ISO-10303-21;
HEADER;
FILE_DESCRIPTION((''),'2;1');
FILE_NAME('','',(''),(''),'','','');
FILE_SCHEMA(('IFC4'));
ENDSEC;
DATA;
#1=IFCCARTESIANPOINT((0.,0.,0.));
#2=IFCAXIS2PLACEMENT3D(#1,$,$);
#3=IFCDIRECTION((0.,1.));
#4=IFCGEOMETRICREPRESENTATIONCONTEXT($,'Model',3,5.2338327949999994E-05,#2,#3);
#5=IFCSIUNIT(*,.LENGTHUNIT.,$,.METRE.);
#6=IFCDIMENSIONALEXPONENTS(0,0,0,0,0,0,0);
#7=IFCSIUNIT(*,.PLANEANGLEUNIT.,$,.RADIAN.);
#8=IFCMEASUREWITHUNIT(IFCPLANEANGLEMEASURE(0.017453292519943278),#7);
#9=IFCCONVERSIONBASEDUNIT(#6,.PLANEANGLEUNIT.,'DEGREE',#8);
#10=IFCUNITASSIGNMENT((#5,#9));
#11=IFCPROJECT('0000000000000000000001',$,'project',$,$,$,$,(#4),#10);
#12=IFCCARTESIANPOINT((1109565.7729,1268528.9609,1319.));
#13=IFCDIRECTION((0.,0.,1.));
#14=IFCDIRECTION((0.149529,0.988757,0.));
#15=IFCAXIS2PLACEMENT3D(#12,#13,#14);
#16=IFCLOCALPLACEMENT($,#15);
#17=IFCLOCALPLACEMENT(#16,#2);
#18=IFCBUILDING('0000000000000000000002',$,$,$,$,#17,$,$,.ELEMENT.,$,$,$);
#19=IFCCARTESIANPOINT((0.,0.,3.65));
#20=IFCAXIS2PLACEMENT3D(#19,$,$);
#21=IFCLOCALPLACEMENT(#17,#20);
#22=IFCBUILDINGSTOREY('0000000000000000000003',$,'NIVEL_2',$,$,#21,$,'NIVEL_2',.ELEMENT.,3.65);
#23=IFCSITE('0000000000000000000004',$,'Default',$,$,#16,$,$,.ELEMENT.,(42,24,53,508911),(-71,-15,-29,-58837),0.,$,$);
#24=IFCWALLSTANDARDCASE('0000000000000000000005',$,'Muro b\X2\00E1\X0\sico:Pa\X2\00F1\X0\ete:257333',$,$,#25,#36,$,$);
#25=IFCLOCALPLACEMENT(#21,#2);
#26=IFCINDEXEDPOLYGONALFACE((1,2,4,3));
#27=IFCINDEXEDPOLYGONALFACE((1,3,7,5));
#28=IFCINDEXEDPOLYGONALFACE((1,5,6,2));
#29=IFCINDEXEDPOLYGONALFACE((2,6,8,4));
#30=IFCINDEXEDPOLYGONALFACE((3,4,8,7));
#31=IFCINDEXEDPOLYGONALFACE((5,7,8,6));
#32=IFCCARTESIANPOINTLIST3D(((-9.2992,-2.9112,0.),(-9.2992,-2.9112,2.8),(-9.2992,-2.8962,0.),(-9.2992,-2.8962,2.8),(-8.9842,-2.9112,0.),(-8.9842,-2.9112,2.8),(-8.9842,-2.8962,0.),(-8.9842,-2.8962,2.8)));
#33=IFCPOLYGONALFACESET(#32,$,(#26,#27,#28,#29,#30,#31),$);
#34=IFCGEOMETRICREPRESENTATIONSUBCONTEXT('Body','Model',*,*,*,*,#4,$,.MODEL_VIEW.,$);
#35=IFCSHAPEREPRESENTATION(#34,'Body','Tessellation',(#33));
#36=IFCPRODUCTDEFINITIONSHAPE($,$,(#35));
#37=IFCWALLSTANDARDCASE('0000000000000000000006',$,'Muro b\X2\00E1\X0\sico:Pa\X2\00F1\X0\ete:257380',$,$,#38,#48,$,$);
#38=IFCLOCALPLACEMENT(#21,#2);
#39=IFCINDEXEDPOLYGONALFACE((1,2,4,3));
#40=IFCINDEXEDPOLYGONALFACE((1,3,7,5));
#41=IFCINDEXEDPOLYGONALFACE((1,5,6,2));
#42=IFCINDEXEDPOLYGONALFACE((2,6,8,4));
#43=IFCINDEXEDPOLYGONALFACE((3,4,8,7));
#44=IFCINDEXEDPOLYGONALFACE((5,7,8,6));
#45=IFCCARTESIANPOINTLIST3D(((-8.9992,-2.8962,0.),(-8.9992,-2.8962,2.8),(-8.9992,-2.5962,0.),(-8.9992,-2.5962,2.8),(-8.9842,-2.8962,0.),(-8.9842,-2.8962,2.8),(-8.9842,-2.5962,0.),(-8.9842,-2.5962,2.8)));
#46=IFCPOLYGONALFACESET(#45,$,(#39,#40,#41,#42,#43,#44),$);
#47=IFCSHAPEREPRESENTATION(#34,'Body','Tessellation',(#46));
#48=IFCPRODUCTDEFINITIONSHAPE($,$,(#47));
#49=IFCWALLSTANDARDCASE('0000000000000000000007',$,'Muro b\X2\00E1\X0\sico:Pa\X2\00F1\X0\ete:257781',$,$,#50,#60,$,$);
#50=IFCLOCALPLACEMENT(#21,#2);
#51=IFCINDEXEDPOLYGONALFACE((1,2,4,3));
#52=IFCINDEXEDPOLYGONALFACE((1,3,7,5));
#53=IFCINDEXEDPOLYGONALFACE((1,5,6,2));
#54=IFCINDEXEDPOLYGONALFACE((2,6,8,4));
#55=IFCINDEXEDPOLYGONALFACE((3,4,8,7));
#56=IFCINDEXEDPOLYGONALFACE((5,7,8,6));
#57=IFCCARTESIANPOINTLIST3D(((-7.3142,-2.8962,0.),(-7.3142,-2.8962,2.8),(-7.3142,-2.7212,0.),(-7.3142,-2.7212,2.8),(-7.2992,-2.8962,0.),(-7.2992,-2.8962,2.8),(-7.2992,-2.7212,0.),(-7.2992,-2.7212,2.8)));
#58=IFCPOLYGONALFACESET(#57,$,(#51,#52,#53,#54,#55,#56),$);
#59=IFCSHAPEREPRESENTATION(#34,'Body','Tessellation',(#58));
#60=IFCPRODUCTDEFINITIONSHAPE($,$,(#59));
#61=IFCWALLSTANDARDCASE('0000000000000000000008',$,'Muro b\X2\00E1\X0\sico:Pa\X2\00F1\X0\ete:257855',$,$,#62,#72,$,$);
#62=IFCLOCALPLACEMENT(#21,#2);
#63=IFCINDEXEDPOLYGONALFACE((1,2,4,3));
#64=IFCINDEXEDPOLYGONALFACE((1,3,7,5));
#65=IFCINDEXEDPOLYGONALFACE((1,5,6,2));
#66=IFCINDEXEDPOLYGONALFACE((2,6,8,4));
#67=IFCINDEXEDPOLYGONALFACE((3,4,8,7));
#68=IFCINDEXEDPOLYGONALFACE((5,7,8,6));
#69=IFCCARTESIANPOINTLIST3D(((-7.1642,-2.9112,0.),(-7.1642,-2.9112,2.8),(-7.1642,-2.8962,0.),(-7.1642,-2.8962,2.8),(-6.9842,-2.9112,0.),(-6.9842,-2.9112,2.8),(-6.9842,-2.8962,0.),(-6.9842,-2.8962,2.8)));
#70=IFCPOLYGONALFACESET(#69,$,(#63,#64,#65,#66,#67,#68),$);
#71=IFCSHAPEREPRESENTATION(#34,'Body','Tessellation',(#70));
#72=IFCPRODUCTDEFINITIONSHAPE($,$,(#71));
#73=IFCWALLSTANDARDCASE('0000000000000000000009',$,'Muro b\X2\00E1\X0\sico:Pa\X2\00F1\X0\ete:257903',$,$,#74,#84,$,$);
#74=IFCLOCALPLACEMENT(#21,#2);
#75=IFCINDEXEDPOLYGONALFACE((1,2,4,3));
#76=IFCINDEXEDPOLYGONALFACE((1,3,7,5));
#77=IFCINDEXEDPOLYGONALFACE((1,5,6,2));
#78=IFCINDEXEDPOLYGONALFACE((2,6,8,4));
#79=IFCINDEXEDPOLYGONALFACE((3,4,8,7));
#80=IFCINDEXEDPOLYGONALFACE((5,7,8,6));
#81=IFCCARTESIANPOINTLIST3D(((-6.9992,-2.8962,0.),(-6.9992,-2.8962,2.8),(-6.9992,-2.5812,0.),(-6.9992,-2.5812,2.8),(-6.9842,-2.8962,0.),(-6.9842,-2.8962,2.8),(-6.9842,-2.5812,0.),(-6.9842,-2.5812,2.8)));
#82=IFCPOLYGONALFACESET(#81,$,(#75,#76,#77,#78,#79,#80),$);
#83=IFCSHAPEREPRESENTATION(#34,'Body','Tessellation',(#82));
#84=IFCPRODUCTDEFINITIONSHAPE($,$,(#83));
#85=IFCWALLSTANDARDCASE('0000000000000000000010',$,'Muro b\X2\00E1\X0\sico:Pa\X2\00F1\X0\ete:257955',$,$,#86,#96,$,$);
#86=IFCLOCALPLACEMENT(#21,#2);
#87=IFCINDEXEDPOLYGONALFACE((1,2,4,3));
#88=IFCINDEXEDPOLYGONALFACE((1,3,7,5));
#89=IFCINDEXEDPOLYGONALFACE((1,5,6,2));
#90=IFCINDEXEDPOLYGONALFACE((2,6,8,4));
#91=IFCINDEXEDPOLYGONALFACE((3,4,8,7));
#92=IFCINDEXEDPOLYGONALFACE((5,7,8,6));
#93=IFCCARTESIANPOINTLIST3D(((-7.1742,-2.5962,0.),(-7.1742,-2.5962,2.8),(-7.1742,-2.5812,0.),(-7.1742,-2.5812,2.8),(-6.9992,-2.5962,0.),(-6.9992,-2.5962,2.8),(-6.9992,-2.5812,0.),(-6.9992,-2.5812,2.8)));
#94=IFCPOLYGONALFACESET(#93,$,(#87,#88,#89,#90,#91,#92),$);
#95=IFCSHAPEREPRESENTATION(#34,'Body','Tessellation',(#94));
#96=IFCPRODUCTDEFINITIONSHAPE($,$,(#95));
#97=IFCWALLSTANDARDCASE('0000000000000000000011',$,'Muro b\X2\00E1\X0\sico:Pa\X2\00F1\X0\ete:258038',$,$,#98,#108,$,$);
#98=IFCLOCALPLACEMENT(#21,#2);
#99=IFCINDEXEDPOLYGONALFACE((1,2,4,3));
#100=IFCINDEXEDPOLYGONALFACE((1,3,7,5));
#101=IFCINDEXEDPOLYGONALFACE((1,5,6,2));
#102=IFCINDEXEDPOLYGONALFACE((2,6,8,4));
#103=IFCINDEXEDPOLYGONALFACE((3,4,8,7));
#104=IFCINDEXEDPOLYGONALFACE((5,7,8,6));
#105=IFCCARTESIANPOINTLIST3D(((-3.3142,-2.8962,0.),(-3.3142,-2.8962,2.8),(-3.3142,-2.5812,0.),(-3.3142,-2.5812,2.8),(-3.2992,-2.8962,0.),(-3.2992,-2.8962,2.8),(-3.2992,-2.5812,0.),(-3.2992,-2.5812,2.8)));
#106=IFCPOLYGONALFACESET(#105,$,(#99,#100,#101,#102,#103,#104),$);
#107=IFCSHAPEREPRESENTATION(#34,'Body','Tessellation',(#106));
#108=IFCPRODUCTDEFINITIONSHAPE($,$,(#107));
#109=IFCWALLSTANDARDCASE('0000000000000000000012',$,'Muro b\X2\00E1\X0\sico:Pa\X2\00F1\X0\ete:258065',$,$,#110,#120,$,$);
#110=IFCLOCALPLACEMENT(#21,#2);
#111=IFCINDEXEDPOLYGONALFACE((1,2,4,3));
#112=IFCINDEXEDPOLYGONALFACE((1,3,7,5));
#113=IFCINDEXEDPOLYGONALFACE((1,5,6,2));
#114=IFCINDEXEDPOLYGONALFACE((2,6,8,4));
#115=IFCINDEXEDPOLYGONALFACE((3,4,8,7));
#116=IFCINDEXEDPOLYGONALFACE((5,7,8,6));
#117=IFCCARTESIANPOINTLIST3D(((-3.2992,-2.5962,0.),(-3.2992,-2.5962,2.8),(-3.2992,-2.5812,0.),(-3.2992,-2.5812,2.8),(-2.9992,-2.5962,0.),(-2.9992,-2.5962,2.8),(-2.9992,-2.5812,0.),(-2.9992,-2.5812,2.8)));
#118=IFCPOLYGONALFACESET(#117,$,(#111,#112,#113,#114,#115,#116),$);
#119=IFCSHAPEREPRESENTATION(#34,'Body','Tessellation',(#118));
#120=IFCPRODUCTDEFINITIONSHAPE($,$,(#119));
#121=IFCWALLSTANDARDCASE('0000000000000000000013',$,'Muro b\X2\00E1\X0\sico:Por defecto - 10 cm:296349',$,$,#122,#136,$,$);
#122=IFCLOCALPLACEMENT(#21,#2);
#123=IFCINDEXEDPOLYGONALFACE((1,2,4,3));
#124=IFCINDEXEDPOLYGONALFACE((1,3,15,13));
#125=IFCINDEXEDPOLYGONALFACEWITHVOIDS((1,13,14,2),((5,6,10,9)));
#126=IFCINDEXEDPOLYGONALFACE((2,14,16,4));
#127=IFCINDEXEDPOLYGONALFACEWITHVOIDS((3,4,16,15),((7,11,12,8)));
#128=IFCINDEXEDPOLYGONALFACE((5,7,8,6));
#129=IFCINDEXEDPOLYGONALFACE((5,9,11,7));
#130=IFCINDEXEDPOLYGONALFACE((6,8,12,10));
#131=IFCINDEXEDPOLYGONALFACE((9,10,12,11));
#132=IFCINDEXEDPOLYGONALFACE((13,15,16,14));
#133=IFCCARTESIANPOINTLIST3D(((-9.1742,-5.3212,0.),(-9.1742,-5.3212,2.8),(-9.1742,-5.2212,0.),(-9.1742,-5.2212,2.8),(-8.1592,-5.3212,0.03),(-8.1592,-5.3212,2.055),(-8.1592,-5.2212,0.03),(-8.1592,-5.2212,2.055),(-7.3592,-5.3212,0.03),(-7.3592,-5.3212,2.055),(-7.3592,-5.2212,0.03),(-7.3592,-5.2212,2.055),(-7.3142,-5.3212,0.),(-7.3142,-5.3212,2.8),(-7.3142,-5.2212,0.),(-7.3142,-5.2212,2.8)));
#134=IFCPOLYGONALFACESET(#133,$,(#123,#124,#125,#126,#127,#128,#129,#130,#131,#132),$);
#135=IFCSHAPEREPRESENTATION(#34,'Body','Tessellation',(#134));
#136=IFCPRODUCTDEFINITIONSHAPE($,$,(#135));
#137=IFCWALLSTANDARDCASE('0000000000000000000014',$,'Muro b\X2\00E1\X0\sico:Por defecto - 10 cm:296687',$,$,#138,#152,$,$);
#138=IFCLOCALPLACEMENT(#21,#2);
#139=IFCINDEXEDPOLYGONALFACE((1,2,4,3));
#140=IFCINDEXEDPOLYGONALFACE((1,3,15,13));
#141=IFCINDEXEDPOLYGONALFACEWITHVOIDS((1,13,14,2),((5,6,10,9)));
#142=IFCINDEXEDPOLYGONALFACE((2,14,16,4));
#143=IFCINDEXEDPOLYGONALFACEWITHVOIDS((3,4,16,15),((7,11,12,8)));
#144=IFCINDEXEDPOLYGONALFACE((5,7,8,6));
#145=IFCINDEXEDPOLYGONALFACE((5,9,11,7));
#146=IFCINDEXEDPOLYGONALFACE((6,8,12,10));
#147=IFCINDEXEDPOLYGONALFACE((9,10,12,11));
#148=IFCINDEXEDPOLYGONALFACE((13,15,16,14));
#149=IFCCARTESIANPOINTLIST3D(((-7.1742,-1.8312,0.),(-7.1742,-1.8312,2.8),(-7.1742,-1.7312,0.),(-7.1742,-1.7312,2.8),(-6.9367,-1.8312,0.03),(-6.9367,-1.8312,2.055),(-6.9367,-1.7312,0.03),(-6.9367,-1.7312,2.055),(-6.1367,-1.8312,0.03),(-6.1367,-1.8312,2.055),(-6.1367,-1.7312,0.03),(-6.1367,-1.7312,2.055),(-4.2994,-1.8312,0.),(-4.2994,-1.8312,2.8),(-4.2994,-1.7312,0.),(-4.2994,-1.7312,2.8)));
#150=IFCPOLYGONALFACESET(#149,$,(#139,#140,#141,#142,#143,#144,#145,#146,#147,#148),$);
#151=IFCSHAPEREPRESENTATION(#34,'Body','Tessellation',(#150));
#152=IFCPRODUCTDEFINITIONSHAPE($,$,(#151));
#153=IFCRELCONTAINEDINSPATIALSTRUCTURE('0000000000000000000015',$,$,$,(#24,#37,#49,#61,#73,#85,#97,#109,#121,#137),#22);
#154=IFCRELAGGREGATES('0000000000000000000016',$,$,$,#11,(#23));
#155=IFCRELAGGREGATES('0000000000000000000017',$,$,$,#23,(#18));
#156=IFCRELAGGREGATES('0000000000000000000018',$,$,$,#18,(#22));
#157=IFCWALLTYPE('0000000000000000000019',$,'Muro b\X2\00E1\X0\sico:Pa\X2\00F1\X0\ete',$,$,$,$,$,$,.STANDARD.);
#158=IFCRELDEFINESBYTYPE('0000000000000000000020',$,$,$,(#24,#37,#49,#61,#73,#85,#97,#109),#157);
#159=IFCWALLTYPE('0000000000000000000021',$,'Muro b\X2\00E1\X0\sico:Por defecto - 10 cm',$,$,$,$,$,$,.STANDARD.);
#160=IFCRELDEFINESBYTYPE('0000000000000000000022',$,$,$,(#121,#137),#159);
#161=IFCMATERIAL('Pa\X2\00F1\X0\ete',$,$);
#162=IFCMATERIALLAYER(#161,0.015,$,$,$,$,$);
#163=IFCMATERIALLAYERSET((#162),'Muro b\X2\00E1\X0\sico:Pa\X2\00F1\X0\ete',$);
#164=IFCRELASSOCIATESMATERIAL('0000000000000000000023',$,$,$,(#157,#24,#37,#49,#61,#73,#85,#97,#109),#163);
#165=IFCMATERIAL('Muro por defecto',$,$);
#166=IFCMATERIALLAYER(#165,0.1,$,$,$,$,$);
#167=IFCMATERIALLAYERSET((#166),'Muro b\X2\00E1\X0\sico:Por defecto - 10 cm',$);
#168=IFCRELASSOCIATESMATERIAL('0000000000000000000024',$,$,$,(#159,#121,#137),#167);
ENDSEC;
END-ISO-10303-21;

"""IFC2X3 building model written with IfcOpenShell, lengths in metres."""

from ifc_helpers import new_model, entity, si_unit, converted_unit, direction, frame, frame_2d, origin, place, context, subcontext, project, spatial, rectangle, extrude, material, layer, layer_set, layer_usage, type_object, element, save


model = new_model("IFC2X3")

# Units and contexts
model_context = context("Model", 3, precision=5.2338327949999994e-05, world=origin(), true_north=direction((0.0, 1.0)))
body_context = subcontext(model_context, "Body", "Model", "MODEL_VIEW")
ifc_project = project(units=[si_unit("LENGTHUNIT", "METRE"), converted_unit("PLANEANGLEUNIT", "DEGREE", entity("IfcPlaneAngleMeasure", 0.017453292519943278), si_unit("PLANEANGLEUNIT", "RADIAN"), dimensions=[0, 0, 0, 0, 0, 0, 0])], contexts=[model_context])

# Site, building, storey
site_placement = place(None, frame((1109565.7729, 1268528.9609, 1319.0), z_axis=(0.0, 0.0, 1.0), x_axis=(0.149529, 0.988757, 0.0)))
site = spatial("IfcSite", under=ifc_project, at=site_placement, Name="Default", CompositionType="ELEMENT", RefLatitude=(42, 24, 53, 508911), RefLongitude=(-71, -15, -29, -58837), RefElevation=0.0)
building_placement = place(site_placement, origin())
building = spatial("IfcBuilding", under=site, at=building_placement, CompositionType="ELEMENT")
storey_placement = place(building_placement, frame((0.0, 0.0, 3.65)))
storey = spatial("IfcBuildingStorey", under=building, at=storey_placement, Name="NIVEL_2", LongName="NIVEL_2", CompositionType="ELEMENT", Elevation=3.65)

# Shared definitions
ifc_material_1 = material(Name="Pañete")

# Walls
ifc_layer_1 = layer(ifc_material_1, 0.015)
ifc_layer_set_1 = layer_set([ifc_layer_1], Name="Muro básico:Pañete")
wall_type_1 = type_object("IfcWallType", Name="Muro básico:Pañete", PredefinedType="STANDARD", material=ifc_layer_set_1)
ifc_layer_usage_1 = layer_usage(ifc_layer_set_1, "AXIS2", "POSITIVE", -0.0075)
wall_1_placement = place(storey_placement, frame((-9.2992, -2.9037, 0.0)))
element("IfcWallStandardCase", 1, at=wall_1_placement, inside=storey, type_object=wall_type_1, material=ifc_layer_usage_1, Name="Muro básico:Pañete:257333", context=body_context, shape_type="SweptSolid", body=[
    extrude(rectangle(XDim=0.315, YDim=0.015, at=frame_2d((0.1575, 0.0), x_axis=(-1.0, 0.0))), origin(), (0.0, 0.0, 1.0), 2.8),
])
ifc_layer_usage_2 = layer_usage(ifc_layer_set_1, "AXIS2", "POSITIVE", -0.0075)
wall_2_placement = place(storey_placement, frame((-8.9917, -2.8962, 0.0), z_axis=(0.0, 0.0, 1.0), x_axis=(0.0, 1.0, 0.0)))
element("IfcWallStandardCase", 2, at=wall_2_placement, inside=storey, type_object=wall_type_1, material=ifc_layer_usage_2, Name="Muro básico:Pañete:257380", context=body_context, shape_type="SweptSolid", body=[
    extrude(rectangle(XDim=0.3, YDim=0.015, at=frame_2d((0.15, 0.0), x_axis=(-1.0, 0.0))), origin(), (0.0, 0.0, 1.0), 2.8),
])
ifc_layer_usage_3 = layer_usage(ifc_layer_set_1, "AXIS2", "NEGATIVE", 0.0075)
wall_3_placement = place(storey_placement, frame((-7.3067, -2.8962, 0.0), z_axis=(0.0, 0.0, 1.0), x_axis=(0.0, 1.0, 0.0)))
element("IfcWallStandardCase", 3, at=wall_3_placement, inside=storey, type_object=wall_type_1, material=ifc_layer_usage_3, Name="Muro básico:Pañete:257781", context=body_context, shape_type="SweptSolid", body=[
    extrude(rectangle(XDim=0.175, YDim=0.015, at=frame_2d((0.0875, 0.0), x_axis=(-1.0, 0.0))), origin(), (0.0, 0.0, 1.0), 2.8),
])
ifc_layer_usage_4 = layer_usage(ifc_layer_set_1, "AXIS2", "POSITIVE", -0.0075)
wall_4_placement = place(storey_placement, frame((-7.1642, -2.9037, 0.0)))
element("IfcWallStandardCase", 4, at=wall_4_placement, inside=storey, type_object=wall_type_1, material=ifc_layer_usage_4, Name="Muro básico:Pañete:257855", context=body_context, shape_type="SweptSolid", body=[
    extrude(rectangle(XDim=0.18, YDim=0.015, at=frame_2d((0.09, 0.0), x_axis=(-1.0, 0.0))), origin(), (0.0, 0.0, 1.0), 2.8),
])
ifc_layer_usage_5 = layer_usage(ifc_layer_set_1, "AXIS2", "POSITIVE", -0.0075)
wall_5_placement = place(storey_placement, frame((-6.9917, -2.8962, 0.0), z_axis=(0.0, 0.0, 1.0), x_axis=(0.0, 1.0, 0.0)))
element("IfcWallStandardCase", 5, at=wall_5_placement, inside=storey, type_object=wall_type_1, material=ifc_layer_usage_5, Name="Muro básico:Pañete:257903", context=body_context, shape_type="SweptSolid", body=[
    extrude(rectangle(XDim=0.315, YDim=0.015, at=frame_2d((0.1575, 0.0), x_axis=(-1.0, 0.0))), origin(), (0.0, 0.0, 1.0), 2.8),
])
ifc_layer_usage_6 = layer_usage(ifc_layer_set_1, "AXIS2", "POSITIVE", -0.0075)
wall_6_placement = place(storey_placement, frame((-6.9992, -2.5887, 0.0), z_axis=(0.0, 0.0, 1.0), x_axis=(-1.0, 0.0, 0.0)))
element("IfcWallStandardCase", 6, at=wall_6_placement, inside=storey, type_object=wall_type_1, material=ifc_layer_usage_6, Name="Muro básico:Pañete:257955", context=body_context, shape_type="SweptSolid", body=[
    extrude(rectangle(XDim=0.175, YDim=0.015, at=frame_2d((0.0875, 0.0), x_axis=(-1.0, 0.0))), origin(), (0.0, 0.0, 1.0), 2.8),
])
ifc_layer_usage_7 = layer_usage(ifc_layer_set_1, "AXIS2", "NEGATIVE", 0.0075)
wall_7_placement = place(storey_placement, frame((-3.3067, -2.8962, 0.0), z_axis=(0.0, 0.0, 1.0), x_axis=(0.0, 1.0, 0.0)))
element("IfcWallStandardCase", 7, at=wall_7_placement, inside=storey, type_object=wall_type_1, material=ifc_layer_usage_7, Name="Muro básico:Pañete:258038", context=body_context, shape_type="SweptSolid", body=[
    extrude(rectangle(XDim=0.315, YDim=0.015, at=frame_2d((0.1575, 0.0), x_axis=(-1.0, 0.0))), origin(), (0.0, 0.0, 1.0), 2.8),
])
ifc_layer_usage_8 = layer_usage(ifc_layer_set_1, "AXIS2", "NEGATIVE", 0.0075)
wall_8_placement = place(storey_placement, frame((-3.2992, -2.5887, 0.0)))
element("IfcWallStandardCase", 8, at=wall_8_placement, inside=storey, type_object=wall_type_1, material=ifc_layer_usage_8, Name="Muro básico:Pañete:258065", context=body_context, shape_type="SweptSolid", body=[
    extrude(rectangle(XDim=0.3, YDim=0.015, at=frame_2d((0.15, 0.0), x_axis=(-1.0, 0.0))), origin(), (0.0, 0.0, 1.0), 2.8),
])

# Walls, openings
ifc_material_2 = material(Name="Muro por defecto")
ifc_layer_2 = layer(ifc_material_2, 0.1)
ifc_layer_set_2 = layer_set([ifc_layer_2], Name="Muro básico:Por defecto - 10 cm")
ifc_layer_usage_9 = layer_usage(ifc_layer_set_2, "AXIS2", "NEGATIVE", 0.05)
wall_type_2 = type_object("IfcWallType", Name="Muro básico:Por defecto - 10 cm", PredefinedType="STANDARD", material=ifc_layer_set_2)
wall_9_placement = place(storey_placement, frame((-9.1742, -5.2712, 0.0)))
wall_9 = element("IfcWallStandardCase", 9, at=wall_9_placement, inside=storey, type_object=wall_type_2, material=ifc_layer_usage_9, Name="Muro básico:Por defecto - 10 cm:296349", context=body_context, shape_type="SweptSolid", body=[
    extrude(rectangle(XDim=1.86, YDim=0.1, at=frame_2d((0.93, 0.0), x_axis=(-1.0, 0.0))), origin(), (0.0, 0.0, 1.0), 2.8),
])
opening_1_placement = place(wall_9_placement, frame((1.815, 0.05, 0.03)))
element("IfcOpeningElement", 10, at=opening_1_placement, cuts=wall_9, ObjectType="Opening", context=body_context, shape_type="SweptSolid", body=[
    extrude(rectangle(XDim=2.025, YDim=0.8, at=frame_2d((1.0125, 0.4), x_axis=(1.0, 0.0))), frame((0.0, 0.0, 0.0), z_axis=(0.0, -1.0, 0.0), x_axis=(0.0, 0.0, 1.0)), (0.0, 0.0, 1.0), 0.1),
])
ifc_layer_usage_10 = layer_usage(ifc_layer_set_2, "AXIS2", "NEGATIVE", 0.05)
wall_10_placement = place(storey_placement, frame((-4.2994, -1.7812, 0.0), z_axis=(0.0, 0.0, 1.0), x_axis=(-1.0, 0.0, 0.0)))
wall_10 = element("IfcWallStandardCase", 11, at=wall_10_placement, inside=storey, type_object=wall_type_2, material=ifc_layer_usage_10, Name="Muro básico:Por defecto - 10 cm:296687", context=body_context, shape_type="SweptSolid", body=[
    extrude(rectangle(XDim=2.8749, YDim=0.1, at=frame_2d((1.4374, 0.0), x_axis=(-1.0, 0.0))), origin(), (0.0, 0.0, 1.0), 2.8),
])
opening_2_placement = place(wall_10_placement, frame((1.8374, -0.05, 0.03)))
element("IfcOpeningElement", 12, at=opening_2_placement, cuts=wall_10, ObjectType="Opening", context=body_context, shape_type="SweptSolid", body=[
    extrude(rectangle(XDim=2.025, YDim=0.8, at=frame_2d((1.0125, 0.4), x_axis=(1.0, 0.0))), frame((0.0, 0.0, 0.0), z_axis=(0.0, 1.0, 0.0), x_axis=(0.0, 0.0, 1.0)), (0.0, 0.0, 1.0), 0.1),
])

save(model, "model.ifc")
